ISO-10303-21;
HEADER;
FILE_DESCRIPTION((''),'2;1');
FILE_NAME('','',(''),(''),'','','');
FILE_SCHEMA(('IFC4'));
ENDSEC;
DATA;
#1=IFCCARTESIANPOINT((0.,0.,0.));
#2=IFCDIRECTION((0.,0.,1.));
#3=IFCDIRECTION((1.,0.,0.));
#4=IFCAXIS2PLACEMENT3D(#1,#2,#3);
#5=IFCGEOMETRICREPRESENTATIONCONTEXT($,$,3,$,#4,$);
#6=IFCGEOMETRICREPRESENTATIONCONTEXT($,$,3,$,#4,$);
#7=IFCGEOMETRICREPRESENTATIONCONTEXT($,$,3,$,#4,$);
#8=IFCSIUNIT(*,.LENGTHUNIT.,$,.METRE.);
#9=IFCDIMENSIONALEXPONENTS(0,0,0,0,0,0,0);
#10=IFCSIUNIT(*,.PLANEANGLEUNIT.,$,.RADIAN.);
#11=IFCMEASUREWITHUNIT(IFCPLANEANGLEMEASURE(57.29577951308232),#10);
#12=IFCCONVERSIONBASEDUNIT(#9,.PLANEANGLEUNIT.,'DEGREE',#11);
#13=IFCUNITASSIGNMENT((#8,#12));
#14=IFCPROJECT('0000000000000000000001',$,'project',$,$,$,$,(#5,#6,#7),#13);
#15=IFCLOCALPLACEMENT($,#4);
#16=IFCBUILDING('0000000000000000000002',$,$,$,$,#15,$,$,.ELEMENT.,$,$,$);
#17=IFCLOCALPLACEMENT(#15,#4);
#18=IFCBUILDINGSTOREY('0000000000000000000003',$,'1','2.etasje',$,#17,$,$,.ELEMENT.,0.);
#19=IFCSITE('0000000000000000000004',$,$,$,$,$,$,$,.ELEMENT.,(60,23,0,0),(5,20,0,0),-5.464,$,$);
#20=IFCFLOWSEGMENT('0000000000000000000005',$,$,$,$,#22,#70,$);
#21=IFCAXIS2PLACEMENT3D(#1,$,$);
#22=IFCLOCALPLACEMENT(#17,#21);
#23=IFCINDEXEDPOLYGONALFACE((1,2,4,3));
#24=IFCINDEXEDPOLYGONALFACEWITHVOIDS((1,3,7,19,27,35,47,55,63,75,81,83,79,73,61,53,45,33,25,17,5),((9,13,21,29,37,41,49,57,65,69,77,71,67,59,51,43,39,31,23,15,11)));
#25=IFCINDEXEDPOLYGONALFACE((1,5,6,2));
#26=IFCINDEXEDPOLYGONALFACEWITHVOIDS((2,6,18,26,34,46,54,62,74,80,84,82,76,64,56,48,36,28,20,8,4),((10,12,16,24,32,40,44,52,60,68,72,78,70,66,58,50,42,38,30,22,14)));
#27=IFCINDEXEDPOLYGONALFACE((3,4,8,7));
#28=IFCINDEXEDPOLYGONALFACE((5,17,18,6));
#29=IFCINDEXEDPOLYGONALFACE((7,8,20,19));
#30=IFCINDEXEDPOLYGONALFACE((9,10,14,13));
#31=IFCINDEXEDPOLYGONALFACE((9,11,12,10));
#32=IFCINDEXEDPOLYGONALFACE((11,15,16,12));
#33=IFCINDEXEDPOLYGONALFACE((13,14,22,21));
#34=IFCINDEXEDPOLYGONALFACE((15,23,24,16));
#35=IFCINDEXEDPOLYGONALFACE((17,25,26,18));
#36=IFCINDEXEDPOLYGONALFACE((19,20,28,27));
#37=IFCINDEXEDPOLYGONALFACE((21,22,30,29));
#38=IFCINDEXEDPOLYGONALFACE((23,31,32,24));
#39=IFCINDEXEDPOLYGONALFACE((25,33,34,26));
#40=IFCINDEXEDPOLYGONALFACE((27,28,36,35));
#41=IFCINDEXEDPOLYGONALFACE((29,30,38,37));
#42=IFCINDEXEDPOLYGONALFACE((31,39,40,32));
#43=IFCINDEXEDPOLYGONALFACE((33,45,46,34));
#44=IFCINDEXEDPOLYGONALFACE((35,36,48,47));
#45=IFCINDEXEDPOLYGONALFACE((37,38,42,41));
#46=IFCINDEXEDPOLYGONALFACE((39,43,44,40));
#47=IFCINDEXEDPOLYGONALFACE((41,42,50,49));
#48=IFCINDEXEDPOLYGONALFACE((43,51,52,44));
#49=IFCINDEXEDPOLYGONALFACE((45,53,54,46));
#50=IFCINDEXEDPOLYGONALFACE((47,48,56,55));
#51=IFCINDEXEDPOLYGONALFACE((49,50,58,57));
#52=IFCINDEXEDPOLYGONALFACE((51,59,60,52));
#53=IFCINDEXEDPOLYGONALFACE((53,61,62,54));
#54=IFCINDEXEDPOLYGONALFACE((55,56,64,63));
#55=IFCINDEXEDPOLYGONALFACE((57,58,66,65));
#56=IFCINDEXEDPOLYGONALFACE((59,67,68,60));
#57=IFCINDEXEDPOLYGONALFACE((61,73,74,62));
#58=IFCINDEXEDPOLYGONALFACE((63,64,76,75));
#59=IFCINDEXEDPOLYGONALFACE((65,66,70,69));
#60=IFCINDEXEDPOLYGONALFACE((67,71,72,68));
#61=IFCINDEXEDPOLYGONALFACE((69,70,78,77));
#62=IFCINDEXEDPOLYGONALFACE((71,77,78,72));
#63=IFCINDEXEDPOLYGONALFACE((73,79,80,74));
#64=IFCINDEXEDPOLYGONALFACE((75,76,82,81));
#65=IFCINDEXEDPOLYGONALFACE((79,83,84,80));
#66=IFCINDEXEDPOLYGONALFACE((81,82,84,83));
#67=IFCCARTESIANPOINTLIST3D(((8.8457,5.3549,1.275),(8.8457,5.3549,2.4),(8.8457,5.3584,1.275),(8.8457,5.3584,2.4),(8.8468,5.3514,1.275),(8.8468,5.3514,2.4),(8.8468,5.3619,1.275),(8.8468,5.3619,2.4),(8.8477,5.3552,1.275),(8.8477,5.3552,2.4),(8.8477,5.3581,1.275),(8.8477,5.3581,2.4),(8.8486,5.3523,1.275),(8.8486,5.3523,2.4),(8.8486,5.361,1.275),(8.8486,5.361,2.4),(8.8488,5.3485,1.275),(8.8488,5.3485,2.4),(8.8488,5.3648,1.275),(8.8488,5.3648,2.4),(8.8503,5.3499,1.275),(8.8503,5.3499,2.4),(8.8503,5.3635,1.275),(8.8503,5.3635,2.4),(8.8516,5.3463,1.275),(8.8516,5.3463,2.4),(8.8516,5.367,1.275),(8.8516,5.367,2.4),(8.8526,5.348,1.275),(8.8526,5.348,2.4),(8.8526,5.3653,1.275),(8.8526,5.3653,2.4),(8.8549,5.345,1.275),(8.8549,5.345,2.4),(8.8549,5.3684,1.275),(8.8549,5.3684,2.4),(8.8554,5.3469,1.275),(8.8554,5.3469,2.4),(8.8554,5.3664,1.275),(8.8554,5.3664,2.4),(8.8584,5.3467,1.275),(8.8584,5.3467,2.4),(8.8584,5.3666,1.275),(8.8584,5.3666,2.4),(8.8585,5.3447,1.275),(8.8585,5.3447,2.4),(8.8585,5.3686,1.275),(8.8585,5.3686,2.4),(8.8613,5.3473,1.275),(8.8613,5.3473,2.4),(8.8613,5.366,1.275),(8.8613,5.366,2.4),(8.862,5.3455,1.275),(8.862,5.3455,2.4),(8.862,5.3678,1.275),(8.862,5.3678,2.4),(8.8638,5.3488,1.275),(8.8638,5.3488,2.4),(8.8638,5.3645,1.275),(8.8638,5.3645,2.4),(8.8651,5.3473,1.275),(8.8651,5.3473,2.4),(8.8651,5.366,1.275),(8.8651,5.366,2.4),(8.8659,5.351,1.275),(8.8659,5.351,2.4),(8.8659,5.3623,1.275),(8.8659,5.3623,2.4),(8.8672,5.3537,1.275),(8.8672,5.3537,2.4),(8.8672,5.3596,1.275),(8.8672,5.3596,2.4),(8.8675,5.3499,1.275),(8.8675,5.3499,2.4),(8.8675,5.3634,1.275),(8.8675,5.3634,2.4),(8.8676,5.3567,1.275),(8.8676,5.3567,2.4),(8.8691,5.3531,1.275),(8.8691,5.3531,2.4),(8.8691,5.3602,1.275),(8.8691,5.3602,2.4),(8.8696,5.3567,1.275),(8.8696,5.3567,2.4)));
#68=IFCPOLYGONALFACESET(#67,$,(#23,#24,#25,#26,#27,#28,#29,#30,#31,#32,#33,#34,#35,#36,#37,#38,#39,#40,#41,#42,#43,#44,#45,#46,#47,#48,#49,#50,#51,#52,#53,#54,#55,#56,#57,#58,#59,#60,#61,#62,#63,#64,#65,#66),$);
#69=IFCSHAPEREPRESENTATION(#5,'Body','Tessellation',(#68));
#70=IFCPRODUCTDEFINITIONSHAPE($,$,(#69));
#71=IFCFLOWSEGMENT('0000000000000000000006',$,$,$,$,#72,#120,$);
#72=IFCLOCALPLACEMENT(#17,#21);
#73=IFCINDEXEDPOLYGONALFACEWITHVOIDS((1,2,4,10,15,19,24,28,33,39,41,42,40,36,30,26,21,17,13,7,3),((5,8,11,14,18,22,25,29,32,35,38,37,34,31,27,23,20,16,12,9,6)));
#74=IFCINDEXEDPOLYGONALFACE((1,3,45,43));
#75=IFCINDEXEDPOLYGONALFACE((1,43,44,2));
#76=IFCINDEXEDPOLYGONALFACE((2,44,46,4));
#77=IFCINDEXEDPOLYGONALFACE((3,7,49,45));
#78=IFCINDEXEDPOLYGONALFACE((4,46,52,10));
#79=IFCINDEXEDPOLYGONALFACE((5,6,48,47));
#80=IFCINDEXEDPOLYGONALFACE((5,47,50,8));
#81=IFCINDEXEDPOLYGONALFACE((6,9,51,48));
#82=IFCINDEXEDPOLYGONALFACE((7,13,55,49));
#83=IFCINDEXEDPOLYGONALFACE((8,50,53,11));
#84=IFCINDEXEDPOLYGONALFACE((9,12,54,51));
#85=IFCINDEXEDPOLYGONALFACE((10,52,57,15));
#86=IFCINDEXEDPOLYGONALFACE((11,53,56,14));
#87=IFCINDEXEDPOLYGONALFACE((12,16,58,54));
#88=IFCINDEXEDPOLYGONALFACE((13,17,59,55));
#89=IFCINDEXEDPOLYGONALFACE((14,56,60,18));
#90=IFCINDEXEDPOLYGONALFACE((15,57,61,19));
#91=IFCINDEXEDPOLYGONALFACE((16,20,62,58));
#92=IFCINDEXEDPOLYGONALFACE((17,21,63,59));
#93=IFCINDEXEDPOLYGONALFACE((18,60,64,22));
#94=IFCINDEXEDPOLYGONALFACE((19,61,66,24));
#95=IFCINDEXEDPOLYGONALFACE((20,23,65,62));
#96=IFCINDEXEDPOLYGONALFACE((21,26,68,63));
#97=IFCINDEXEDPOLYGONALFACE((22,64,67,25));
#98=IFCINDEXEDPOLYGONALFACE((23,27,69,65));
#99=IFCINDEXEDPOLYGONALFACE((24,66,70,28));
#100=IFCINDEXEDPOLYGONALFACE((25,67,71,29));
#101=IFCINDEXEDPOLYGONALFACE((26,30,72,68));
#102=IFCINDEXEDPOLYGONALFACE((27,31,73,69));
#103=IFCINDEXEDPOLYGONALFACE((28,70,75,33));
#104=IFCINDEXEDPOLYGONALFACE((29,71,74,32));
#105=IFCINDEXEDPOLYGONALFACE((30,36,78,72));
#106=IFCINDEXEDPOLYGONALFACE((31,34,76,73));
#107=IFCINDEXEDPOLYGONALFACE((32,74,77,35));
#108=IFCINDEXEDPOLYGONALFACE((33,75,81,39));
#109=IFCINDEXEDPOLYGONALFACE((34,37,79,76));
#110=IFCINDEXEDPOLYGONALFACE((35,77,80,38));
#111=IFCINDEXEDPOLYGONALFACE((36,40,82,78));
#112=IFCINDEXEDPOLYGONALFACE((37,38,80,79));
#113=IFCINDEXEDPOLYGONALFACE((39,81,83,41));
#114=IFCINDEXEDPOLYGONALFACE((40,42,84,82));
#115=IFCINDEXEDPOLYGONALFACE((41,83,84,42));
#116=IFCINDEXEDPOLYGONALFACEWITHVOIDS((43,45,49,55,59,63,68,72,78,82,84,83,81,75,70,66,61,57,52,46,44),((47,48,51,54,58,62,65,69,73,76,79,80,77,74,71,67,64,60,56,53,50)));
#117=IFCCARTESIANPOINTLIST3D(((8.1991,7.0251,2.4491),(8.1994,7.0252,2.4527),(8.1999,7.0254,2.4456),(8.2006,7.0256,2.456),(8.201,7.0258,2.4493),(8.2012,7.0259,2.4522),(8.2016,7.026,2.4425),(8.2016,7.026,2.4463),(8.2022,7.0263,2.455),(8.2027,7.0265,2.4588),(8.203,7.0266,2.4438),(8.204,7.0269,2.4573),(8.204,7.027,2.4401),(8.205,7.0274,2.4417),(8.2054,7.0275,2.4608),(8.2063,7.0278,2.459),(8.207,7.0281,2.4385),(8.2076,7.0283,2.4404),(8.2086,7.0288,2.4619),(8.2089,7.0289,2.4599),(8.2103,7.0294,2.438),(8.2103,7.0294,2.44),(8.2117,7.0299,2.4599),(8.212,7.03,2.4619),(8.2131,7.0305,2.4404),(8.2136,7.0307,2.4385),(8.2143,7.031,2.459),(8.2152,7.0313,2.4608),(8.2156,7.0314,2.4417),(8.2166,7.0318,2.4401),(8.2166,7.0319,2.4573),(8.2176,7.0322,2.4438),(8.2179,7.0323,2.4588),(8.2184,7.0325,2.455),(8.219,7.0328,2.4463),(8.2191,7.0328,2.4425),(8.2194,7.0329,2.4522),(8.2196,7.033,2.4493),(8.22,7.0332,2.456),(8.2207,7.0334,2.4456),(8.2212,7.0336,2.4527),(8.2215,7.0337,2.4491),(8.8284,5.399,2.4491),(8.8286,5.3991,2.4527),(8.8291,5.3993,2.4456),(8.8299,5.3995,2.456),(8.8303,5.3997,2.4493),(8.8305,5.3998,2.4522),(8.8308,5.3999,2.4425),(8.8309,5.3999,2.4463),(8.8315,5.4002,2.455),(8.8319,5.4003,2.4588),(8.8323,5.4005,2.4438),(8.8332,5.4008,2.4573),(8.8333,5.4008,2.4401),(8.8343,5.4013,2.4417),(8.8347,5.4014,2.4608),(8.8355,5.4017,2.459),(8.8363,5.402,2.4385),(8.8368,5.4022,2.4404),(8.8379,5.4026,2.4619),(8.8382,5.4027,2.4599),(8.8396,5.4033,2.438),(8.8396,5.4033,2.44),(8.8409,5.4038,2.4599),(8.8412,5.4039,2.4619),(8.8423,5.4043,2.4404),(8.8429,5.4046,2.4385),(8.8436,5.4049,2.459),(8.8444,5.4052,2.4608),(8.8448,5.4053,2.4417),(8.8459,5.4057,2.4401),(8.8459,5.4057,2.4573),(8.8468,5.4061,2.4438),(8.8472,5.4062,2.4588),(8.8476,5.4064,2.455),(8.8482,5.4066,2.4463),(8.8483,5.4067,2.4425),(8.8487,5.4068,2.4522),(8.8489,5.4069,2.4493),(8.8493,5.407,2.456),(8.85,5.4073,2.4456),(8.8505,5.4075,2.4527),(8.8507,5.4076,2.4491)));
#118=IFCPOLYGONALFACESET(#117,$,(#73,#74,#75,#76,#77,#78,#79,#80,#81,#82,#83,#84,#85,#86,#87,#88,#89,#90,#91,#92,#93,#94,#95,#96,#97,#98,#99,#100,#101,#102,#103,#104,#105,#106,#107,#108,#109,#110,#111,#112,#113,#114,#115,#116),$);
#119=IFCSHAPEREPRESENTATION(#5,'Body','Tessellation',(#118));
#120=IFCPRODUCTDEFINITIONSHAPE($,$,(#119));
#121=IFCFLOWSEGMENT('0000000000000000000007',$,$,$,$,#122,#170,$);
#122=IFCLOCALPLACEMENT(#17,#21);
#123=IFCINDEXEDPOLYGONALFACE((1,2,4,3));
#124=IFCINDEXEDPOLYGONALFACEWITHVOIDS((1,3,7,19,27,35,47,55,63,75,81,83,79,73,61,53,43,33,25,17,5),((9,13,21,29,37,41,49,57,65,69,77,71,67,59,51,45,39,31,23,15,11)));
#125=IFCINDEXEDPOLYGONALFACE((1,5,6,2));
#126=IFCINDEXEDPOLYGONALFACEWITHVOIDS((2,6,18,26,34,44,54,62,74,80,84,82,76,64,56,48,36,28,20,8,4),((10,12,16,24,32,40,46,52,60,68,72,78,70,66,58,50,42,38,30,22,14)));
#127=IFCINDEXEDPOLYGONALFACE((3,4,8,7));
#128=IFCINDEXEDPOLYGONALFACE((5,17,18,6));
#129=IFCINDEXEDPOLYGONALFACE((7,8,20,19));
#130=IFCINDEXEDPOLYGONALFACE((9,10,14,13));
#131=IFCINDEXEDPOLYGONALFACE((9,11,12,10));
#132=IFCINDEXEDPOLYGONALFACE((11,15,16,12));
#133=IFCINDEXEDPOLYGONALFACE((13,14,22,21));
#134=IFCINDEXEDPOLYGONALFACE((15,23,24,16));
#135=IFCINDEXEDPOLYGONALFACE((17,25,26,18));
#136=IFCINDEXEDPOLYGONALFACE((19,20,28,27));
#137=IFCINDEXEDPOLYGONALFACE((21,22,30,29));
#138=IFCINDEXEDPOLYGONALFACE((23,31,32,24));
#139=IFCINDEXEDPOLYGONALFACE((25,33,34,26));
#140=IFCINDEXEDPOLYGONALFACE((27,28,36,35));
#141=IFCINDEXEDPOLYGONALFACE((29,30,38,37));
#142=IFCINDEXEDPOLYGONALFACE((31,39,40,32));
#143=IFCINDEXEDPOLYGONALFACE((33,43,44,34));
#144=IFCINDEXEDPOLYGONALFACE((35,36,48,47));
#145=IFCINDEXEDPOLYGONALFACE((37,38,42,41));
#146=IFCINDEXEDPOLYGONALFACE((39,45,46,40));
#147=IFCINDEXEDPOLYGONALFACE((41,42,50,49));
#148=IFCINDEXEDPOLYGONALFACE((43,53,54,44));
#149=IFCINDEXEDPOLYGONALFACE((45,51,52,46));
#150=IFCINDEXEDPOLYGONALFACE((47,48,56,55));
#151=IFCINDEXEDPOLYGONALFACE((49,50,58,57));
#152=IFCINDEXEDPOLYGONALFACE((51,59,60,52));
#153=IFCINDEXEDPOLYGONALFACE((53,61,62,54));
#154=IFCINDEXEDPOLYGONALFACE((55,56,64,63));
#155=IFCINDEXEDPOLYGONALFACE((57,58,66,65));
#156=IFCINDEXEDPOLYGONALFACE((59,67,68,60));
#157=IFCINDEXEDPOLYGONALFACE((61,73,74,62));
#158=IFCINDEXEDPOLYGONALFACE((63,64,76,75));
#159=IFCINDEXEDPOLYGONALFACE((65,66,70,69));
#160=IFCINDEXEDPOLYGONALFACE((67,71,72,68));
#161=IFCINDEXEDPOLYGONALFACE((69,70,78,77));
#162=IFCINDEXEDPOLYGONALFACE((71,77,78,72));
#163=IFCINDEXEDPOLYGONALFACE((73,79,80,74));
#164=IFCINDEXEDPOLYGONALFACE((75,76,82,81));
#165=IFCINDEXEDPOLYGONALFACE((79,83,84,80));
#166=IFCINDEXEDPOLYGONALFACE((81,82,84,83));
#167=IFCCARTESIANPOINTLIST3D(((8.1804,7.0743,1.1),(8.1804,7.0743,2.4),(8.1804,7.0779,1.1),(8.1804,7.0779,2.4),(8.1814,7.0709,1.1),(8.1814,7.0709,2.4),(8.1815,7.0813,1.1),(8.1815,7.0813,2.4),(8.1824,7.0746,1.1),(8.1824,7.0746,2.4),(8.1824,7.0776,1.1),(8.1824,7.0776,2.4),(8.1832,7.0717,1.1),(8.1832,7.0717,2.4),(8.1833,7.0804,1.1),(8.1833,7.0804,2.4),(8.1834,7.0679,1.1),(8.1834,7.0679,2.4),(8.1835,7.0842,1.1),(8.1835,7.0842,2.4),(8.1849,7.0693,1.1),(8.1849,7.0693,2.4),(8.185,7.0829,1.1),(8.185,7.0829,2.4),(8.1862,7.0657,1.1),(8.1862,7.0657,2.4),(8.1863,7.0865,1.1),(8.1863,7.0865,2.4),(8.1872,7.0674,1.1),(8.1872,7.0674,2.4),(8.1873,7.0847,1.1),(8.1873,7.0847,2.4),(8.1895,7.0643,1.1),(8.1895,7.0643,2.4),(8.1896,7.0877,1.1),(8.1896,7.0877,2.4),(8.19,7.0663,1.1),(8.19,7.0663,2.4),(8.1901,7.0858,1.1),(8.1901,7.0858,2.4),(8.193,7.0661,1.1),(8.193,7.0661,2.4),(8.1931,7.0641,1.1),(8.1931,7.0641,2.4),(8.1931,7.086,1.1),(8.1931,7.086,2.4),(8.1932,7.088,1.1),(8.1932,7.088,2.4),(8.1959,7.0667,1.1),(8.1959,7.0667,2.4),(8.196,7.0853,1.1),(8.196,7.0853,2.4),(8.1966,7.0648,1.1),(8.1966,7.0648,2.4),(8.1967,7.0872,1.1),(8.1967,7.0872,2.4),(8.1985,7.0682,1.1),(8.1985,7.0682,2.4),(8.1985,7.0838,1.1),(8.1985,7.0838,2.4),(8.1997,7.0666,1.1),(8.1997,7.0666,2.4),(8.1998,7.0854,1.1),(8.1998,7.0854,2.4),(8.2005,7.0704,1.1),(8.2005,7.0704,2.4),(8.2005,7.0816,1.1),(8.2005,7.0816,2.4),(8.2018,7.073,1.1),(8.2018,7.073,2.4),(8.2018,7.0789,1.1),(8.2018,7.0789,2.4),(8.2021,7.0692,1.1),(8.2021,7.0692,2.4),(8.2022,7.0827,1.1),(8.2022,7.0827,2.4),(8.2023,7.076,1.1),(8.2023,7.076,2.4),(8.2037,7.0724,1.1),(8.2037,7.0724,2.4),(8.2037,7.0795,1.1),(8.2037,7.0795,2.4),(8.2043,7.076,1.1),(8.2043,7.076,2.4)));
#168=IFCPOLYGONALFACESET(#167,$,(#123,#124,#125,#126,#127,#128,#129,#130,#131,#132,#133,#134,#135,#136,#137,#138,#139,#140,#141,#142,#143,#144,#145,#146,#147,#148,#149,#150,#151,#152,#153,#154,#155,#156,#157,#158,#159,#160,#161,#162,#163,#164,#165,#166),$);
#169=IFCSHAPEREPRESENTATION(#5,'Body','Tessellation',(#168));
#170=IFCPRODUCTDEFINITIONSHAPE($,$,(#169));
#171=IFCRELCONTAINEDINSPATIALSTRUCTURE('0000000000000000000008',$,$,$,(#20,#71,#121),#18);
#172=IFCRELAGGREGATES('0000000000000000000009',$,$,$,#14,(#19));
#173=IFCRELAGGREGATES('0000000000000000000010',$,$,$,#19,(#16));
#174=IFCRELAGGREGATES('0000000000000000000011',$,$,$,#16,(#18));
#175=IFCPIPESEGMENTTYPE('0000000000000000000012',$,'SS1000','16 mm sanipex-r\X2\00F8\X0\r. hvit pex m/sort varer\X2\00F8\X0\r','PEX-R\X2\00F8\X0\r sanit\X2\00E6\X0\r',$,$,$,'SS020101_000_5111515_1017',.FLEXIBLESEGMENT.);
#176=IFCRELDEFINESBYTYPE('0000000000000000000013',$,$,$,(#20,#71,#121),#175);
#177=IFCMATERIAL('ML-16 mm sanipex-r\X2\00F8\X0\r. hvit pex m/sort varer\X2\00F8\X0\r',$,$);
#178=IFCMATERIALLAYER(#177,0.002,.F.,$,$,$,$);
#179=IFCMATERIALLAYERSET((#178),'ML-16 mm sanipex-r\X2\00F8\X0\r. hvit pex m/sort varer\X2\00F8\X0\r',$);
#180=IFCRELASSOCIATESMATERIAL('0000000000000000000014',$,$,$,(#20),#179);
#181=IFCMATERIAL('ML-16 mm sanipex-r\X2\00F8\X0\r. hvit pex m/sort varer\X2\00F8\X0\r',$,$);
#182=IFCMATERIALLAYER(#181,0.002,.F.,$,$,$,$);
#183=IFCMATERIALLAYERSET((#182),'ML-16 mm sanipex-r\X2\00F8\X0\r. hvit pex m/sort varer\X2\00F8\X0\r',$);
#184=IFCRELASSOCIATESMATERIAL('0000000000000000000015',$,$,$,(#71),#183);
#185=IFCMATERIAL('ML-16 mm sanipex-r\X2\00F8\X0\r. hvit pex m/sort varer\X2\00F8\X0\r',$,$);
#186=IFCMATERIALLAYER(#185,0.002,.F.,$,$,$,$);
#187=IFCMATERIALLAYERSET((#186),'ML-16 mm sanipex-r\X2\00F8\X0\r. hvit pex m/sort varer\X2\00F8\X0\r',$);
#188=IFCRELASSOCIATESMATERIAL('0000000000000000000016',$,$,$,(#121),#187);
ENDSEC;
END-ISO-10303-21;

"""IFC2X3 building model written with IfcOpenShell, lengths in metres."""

from ifc_helpers import new_model, entity, si_unit, converted_unit, frame, origin_with_axes, origin_2d_with_axis, place, context, project, spatial, hollow_circle, extrude, material, layer, layer_set, layer_usage, type_object, element, save


model = new_model("IFC2X3")

# Units and contexts
context_of_model_1 = context(None, 3, world=origin_with_axes())
context_of_model_2 = context(None, 3, world=origin_with_axes())
context_of_model_3 = context(None, 3, world=origin_with_axes())
ifc_project = project(units=[si_unit("LENGTHUNIT", "METRE"), converted_unit("PLANEANGLEUNIT", "DEGREE", entity("IfcPlaneAngleMeasure", 57.29577951308232), si_unit("PLANEANGLEUNIT", "RADIAN"), dimensions=[0, 0, 0, 0, 0, 0, 0])], contexts=[context_of_model_1, context_of_model_2, context_of_model_3])

# Site, building, storey
site = spatial("IfcSite", under=ifc_project, CompositionType="ELEMENT", RefLatitude=(60, 23, 0, 0), RefLongitude=(5, 20, 0, 0), RefElevation=-5.464)
building_placement = place(None, origin_with_axes())
building = spatial("IfcBuilding", under=site, at=building_placement, CompositionType="ELEMENT")
storey_placement = place(building_placement, origin_with_axes())
storey = spatial("IfcBuildingStorey", under=building, at=storey_placement, Name="1", Description="2.etasje", CompositionType="ELEMENT", Elevation=0.0)

# Flow segments
pipe_segment_type_1 = type_object("IfcPipeSegmentType", Name="SS1000", Description="16 mm sanipex-rør. hvit pex m/sort varerør", ApplicableOccurrence="PEX-Rør sanitær", ElementType="SS020101_000_5111515_1017", PredefinedType="FLEXIBLESEGMENT")
ifc_material_1 = material(Name="ML-16 mm sanipex-rør. hvit pex m/sort varerør")
ifc_layer_1 = layer(ifc_material_1, 0.002, ventilated=False)
ifc_layer_set_1 = layer_set([ifc_layer_1], Name="ML-16 mm sanipex-rør. hvit pex m/sort varerør")
ifc_layer_usage_1 = layer_usage(ifc_layer_set_1, "AXIS2", "POSITIVE", 0.0)
flow_segment_1_placement = place(storey_placement, frame((8.8576, 5.3567, 1.275), z_axis=(0.0, 0.0, 1.0), x_axis=(1.0, 0.0, 0.0)))
element("IfcFlowSegment", 1, at=flow_segment_1_placement, inside=storey, type_object=pipe_segment_type_1, material=ifc_layer_usage_1, context=context_of_model_1, shape_type="SweptSolid", body=[
    extrude(hollow_circle(Radius=0.012, WallThickness=0.002, at=origin_2d_with_axis()), origin_with_axes(), (0.0, 0.0, 1.0), 1.125),
])
ifc_material_2 = material(Name="ML-16 mm sanipex-rør. hvit pex m/sort varerør")
ifc_layer_2 = layer(ifc_material_2, 0.002, ventilated=False)
ifc_layer_set_2 = layer_set([ifc_layer_2], Name="ML-16 mm sanipex-rør. hvit pex m/sort varerør")
ifc_layer_usage_2 = layer_usage(ifc_layer_set_2, "AXIS2", "POSITIVE", 0.0)
flow_segment_2_placement = place(storey_placement, frame((8.8396, 5.4033, 2.45), z_axis=(-0.36089, 0.932608, 0.0), x_axis=(0.0, 0.0, -1.0)))
element("IfcFlowSegment", 2, at=flow_segment_2_placement, inside=storey, type_object=pipe_segment_type_1, material=ifc_layer_usage_2, context=context_of_model_1, shape_type="SweptSolid", body=[
    extrude(hollow_circle(Radius=0.012, WallThickness=0.002, at=origin_2d_with_axis()), origin_with_axes(), (0.0, 0.0, 1.0), 1.7436),
])
ifc_material_3 = material(Name="ML-16 mm sanipex-rør. hvit pex m/sort varerør")
ifc_layer_3 = layer(ifc_material_3, 0.002, ventilated=False)
ifc_layer_set_3 = layer_set([ifc_layer_3], Name="ML-16 mm sanipex-rør. hvit pex m/sort varerør")
ifc_layer_usage_3 = layer_usage(ifc_layer_set_3, "AXIS2", "POSITIVE", 0.0)
flow_segment_3_placement = place(storey_placement, frame((8.1923, 7.076, 2.4), z_axis=(0.0, 0.0, -1.0), x_axis=(0.36089, -0.932608, 0.0)))
element("IfcFlowSegment", 3, at=flow_segment_3_placement, inside=storey, type_object=pipe_segment_type_1, material=ifc_layer_usage_3, context=context_of_model_1, shape_type="SweptSolid", body=[
    extrude(hollow_circle(Radius=0.012, WallThickness=0.002, at=origin_2d_with_axis()), origin_with_axes(), (0.0, 0.0, 1.0), 1.3),
])

save(model, "model.ifc")
